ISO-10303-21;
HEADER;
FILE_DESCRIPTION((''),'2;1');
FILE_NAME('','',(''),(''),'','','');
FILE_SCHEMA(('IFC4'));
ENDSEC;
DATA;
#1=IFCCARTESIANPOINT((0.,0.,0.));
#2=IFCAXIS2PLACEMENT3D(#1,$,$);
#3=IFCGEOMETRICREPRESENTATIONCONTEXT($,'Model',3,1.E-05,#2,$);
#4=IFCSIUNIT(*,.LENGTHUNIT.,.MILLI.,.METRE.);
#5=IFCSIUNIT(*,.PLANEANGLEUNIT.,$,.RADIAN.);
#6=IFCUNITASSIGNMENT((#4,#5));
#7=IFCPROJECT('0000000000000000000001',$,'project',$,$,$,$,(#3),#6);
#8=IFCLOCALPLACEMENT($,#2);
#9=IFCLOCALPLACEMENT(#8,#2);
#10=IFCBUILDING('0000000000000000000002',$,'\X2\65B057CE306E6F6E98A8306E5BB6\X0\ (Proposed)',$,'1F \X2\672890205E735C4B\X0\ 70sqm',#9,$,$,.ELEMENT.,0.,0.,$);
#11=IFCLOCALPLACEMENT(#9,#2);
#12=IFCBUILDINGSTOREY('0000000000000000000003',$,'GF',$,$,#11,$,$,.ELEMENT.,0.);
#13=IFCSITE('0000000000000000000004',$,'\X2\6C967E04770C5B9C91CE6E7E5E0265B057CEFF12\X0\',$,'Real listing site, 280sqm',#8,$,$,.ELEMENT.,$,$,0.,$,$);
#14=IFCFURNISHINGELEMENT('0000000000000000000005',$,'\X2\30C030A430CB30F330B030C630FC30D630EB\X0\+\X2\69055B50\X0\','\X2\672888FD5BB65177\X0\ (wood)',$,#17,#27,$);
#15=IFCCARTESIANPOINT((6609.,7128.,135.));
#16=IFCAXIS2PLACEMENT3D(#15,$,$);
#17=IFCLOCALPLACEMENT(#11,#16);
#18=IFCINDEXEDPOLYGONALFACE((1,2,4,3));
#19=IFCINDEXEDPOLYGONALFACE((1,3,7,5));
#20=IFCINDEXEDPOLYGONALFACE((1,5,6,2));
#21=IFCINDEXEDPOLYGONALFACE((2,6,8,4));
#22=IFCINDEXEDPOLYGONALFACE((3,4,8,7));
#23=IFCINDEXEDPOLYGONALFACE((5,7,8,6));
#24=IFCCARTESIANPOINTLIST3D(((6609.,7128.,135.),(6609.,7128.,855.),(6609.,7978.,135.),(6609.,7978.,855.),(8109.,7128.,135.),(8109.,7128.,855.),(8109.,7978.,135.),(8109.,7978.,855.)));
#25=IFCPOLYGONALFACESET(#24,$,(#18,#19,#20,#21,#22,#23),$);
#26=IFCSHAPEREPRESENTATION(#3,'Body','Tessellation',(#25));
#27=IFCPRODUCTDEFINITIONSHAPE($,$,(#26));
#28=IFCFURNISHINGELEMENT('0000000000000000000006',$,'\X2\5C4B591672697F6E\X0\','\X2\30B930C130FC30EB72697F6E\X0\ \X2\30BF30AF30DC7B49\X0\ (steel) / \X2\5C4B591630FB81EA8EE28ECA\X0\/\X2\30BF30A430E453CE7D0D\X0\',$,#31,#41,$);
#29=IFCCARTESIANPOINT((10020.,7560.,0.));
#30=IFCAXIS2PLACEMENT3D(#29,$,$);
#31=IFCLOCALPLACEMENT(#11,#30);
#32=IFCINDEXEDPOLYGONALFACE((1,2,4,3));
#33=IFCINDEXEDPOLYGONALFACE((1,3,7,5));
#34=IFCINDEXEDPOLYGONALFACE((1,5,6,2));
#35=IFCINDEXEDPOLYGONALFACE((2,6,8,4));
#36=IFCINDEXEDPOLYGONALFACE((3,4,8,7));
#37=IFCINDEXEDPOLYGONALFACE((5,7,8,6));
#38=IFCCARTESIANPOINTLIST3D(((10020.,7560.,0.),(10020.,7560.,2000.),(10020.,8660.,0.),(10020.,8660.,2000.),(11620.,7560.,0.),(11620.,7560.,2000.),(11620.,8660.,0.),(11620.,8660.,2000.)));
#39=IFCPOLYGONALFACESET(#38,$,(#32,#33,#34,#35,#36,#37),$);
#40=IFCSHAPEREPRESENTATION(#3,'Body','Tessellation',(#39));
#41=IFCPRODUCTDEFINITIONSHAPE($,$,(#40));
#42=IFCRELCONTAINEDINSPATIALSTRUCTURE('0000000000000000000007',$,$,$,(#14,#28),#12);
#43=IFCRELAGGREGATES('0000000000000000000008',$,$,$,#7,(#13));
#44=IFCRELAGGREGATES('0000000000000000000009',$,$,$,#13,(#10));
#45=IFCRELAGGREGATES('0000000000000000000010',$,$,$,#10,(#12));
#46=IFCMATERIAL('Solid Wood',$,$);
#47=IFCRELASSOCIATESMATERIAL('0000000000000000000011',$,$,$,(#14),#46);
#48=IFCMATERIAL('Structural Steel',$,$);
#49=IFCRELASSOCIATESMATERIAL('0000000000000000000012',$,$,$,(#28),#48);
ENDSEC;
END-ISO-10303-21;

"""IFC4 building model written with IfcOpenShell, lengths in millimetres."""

from ifc_helpers import new_model, si_unit, frame, frame_2d, origin, place, context, project, spatial, rectangle, extrude, material, element, save


model = new_model("IFC4")

# Units and contexts
model_context = context("Model", 3, precision=1e-05, world=origin())
ifc_project = project(units=[si_unit("LENGTHUNIT", "METRE", prefix="MILLI"), si_unit("PLANEANGLEUNIT", "RADIAN")], contexts=[model_context])

# Site, building, storey
site_placement = place(None, origin())
site = spatial("IfcSite", under=ifc_project, at=site_placement, Name="沖縄県宜野湾市新城２", ObjectType="Real listing site, 280sqm", CompositionType="ELEMENT", RefElevation=0.0)
building_placement = place(site_placement, origin())
building = spatial("IfcBuilding", under=site, at=building_placement, Name="新城の潮風の家 (Proposed)", ObjectType="1F 木造平屋 70sqm", CompositionType="ELEMENT", ElevationOfRefHeight=0.0, ElevationOfTerrain=0.0)
storey_placement = place(building_placement, origin())
storey = spatial("IfcBuildingStorey", under=building, at=storey_placement, Name="GF", CompositionType="ELEMENT", Elevation=0.0)

# Shared definitions
ifc_material_1 = material(Name="Solid Wood")

# Shared definitions
ifc_material_2 = material(Name="Structural Steel")

# Furnishing elements
furnishing_1_placement = place(storey_placement, frame((6609.0, 7128.0, 135.0)))
element("IfcFurnishingElement", 1, at=furnishing_1_placement, inside=storey, material=ifc_material_1, Name="ダイニングテーブル+椅子", Description="木製家具 (wood)", context=model_context, shape_type="SweptSolid", body=[
    extrude(rectangle(XDim=1500.0, YDim=850.0, at=frame_2d((750.0, 425.0))), frame((6609.0, 7128.0, 135.0)), (0.0, 0.0, 1.0), 720.0),
])
furnishing_2_placement = place(storey_placement, frame((10020.0, 7560.0, 0.0)))
element("IfcFurnishingElement", 2, at=furnishing_2_placement, inside=storey, material=ifc_material_2, Name="屋外物置", Description="スチール物置 タクボ等 (steel) / 屋外・自転車/タイヤ収納", context=model_context, shape_type="SweptSolid", body=[
    extrude(rectangle(XDim=1600.0, YDim=1100.0, at=frame_2d((800.0, 550.0))), frame((10020.0, 7560.0, 0.0)), (0.0, 0.0, 1.0), 2000.0),
])

save(model, "model.ifc")
